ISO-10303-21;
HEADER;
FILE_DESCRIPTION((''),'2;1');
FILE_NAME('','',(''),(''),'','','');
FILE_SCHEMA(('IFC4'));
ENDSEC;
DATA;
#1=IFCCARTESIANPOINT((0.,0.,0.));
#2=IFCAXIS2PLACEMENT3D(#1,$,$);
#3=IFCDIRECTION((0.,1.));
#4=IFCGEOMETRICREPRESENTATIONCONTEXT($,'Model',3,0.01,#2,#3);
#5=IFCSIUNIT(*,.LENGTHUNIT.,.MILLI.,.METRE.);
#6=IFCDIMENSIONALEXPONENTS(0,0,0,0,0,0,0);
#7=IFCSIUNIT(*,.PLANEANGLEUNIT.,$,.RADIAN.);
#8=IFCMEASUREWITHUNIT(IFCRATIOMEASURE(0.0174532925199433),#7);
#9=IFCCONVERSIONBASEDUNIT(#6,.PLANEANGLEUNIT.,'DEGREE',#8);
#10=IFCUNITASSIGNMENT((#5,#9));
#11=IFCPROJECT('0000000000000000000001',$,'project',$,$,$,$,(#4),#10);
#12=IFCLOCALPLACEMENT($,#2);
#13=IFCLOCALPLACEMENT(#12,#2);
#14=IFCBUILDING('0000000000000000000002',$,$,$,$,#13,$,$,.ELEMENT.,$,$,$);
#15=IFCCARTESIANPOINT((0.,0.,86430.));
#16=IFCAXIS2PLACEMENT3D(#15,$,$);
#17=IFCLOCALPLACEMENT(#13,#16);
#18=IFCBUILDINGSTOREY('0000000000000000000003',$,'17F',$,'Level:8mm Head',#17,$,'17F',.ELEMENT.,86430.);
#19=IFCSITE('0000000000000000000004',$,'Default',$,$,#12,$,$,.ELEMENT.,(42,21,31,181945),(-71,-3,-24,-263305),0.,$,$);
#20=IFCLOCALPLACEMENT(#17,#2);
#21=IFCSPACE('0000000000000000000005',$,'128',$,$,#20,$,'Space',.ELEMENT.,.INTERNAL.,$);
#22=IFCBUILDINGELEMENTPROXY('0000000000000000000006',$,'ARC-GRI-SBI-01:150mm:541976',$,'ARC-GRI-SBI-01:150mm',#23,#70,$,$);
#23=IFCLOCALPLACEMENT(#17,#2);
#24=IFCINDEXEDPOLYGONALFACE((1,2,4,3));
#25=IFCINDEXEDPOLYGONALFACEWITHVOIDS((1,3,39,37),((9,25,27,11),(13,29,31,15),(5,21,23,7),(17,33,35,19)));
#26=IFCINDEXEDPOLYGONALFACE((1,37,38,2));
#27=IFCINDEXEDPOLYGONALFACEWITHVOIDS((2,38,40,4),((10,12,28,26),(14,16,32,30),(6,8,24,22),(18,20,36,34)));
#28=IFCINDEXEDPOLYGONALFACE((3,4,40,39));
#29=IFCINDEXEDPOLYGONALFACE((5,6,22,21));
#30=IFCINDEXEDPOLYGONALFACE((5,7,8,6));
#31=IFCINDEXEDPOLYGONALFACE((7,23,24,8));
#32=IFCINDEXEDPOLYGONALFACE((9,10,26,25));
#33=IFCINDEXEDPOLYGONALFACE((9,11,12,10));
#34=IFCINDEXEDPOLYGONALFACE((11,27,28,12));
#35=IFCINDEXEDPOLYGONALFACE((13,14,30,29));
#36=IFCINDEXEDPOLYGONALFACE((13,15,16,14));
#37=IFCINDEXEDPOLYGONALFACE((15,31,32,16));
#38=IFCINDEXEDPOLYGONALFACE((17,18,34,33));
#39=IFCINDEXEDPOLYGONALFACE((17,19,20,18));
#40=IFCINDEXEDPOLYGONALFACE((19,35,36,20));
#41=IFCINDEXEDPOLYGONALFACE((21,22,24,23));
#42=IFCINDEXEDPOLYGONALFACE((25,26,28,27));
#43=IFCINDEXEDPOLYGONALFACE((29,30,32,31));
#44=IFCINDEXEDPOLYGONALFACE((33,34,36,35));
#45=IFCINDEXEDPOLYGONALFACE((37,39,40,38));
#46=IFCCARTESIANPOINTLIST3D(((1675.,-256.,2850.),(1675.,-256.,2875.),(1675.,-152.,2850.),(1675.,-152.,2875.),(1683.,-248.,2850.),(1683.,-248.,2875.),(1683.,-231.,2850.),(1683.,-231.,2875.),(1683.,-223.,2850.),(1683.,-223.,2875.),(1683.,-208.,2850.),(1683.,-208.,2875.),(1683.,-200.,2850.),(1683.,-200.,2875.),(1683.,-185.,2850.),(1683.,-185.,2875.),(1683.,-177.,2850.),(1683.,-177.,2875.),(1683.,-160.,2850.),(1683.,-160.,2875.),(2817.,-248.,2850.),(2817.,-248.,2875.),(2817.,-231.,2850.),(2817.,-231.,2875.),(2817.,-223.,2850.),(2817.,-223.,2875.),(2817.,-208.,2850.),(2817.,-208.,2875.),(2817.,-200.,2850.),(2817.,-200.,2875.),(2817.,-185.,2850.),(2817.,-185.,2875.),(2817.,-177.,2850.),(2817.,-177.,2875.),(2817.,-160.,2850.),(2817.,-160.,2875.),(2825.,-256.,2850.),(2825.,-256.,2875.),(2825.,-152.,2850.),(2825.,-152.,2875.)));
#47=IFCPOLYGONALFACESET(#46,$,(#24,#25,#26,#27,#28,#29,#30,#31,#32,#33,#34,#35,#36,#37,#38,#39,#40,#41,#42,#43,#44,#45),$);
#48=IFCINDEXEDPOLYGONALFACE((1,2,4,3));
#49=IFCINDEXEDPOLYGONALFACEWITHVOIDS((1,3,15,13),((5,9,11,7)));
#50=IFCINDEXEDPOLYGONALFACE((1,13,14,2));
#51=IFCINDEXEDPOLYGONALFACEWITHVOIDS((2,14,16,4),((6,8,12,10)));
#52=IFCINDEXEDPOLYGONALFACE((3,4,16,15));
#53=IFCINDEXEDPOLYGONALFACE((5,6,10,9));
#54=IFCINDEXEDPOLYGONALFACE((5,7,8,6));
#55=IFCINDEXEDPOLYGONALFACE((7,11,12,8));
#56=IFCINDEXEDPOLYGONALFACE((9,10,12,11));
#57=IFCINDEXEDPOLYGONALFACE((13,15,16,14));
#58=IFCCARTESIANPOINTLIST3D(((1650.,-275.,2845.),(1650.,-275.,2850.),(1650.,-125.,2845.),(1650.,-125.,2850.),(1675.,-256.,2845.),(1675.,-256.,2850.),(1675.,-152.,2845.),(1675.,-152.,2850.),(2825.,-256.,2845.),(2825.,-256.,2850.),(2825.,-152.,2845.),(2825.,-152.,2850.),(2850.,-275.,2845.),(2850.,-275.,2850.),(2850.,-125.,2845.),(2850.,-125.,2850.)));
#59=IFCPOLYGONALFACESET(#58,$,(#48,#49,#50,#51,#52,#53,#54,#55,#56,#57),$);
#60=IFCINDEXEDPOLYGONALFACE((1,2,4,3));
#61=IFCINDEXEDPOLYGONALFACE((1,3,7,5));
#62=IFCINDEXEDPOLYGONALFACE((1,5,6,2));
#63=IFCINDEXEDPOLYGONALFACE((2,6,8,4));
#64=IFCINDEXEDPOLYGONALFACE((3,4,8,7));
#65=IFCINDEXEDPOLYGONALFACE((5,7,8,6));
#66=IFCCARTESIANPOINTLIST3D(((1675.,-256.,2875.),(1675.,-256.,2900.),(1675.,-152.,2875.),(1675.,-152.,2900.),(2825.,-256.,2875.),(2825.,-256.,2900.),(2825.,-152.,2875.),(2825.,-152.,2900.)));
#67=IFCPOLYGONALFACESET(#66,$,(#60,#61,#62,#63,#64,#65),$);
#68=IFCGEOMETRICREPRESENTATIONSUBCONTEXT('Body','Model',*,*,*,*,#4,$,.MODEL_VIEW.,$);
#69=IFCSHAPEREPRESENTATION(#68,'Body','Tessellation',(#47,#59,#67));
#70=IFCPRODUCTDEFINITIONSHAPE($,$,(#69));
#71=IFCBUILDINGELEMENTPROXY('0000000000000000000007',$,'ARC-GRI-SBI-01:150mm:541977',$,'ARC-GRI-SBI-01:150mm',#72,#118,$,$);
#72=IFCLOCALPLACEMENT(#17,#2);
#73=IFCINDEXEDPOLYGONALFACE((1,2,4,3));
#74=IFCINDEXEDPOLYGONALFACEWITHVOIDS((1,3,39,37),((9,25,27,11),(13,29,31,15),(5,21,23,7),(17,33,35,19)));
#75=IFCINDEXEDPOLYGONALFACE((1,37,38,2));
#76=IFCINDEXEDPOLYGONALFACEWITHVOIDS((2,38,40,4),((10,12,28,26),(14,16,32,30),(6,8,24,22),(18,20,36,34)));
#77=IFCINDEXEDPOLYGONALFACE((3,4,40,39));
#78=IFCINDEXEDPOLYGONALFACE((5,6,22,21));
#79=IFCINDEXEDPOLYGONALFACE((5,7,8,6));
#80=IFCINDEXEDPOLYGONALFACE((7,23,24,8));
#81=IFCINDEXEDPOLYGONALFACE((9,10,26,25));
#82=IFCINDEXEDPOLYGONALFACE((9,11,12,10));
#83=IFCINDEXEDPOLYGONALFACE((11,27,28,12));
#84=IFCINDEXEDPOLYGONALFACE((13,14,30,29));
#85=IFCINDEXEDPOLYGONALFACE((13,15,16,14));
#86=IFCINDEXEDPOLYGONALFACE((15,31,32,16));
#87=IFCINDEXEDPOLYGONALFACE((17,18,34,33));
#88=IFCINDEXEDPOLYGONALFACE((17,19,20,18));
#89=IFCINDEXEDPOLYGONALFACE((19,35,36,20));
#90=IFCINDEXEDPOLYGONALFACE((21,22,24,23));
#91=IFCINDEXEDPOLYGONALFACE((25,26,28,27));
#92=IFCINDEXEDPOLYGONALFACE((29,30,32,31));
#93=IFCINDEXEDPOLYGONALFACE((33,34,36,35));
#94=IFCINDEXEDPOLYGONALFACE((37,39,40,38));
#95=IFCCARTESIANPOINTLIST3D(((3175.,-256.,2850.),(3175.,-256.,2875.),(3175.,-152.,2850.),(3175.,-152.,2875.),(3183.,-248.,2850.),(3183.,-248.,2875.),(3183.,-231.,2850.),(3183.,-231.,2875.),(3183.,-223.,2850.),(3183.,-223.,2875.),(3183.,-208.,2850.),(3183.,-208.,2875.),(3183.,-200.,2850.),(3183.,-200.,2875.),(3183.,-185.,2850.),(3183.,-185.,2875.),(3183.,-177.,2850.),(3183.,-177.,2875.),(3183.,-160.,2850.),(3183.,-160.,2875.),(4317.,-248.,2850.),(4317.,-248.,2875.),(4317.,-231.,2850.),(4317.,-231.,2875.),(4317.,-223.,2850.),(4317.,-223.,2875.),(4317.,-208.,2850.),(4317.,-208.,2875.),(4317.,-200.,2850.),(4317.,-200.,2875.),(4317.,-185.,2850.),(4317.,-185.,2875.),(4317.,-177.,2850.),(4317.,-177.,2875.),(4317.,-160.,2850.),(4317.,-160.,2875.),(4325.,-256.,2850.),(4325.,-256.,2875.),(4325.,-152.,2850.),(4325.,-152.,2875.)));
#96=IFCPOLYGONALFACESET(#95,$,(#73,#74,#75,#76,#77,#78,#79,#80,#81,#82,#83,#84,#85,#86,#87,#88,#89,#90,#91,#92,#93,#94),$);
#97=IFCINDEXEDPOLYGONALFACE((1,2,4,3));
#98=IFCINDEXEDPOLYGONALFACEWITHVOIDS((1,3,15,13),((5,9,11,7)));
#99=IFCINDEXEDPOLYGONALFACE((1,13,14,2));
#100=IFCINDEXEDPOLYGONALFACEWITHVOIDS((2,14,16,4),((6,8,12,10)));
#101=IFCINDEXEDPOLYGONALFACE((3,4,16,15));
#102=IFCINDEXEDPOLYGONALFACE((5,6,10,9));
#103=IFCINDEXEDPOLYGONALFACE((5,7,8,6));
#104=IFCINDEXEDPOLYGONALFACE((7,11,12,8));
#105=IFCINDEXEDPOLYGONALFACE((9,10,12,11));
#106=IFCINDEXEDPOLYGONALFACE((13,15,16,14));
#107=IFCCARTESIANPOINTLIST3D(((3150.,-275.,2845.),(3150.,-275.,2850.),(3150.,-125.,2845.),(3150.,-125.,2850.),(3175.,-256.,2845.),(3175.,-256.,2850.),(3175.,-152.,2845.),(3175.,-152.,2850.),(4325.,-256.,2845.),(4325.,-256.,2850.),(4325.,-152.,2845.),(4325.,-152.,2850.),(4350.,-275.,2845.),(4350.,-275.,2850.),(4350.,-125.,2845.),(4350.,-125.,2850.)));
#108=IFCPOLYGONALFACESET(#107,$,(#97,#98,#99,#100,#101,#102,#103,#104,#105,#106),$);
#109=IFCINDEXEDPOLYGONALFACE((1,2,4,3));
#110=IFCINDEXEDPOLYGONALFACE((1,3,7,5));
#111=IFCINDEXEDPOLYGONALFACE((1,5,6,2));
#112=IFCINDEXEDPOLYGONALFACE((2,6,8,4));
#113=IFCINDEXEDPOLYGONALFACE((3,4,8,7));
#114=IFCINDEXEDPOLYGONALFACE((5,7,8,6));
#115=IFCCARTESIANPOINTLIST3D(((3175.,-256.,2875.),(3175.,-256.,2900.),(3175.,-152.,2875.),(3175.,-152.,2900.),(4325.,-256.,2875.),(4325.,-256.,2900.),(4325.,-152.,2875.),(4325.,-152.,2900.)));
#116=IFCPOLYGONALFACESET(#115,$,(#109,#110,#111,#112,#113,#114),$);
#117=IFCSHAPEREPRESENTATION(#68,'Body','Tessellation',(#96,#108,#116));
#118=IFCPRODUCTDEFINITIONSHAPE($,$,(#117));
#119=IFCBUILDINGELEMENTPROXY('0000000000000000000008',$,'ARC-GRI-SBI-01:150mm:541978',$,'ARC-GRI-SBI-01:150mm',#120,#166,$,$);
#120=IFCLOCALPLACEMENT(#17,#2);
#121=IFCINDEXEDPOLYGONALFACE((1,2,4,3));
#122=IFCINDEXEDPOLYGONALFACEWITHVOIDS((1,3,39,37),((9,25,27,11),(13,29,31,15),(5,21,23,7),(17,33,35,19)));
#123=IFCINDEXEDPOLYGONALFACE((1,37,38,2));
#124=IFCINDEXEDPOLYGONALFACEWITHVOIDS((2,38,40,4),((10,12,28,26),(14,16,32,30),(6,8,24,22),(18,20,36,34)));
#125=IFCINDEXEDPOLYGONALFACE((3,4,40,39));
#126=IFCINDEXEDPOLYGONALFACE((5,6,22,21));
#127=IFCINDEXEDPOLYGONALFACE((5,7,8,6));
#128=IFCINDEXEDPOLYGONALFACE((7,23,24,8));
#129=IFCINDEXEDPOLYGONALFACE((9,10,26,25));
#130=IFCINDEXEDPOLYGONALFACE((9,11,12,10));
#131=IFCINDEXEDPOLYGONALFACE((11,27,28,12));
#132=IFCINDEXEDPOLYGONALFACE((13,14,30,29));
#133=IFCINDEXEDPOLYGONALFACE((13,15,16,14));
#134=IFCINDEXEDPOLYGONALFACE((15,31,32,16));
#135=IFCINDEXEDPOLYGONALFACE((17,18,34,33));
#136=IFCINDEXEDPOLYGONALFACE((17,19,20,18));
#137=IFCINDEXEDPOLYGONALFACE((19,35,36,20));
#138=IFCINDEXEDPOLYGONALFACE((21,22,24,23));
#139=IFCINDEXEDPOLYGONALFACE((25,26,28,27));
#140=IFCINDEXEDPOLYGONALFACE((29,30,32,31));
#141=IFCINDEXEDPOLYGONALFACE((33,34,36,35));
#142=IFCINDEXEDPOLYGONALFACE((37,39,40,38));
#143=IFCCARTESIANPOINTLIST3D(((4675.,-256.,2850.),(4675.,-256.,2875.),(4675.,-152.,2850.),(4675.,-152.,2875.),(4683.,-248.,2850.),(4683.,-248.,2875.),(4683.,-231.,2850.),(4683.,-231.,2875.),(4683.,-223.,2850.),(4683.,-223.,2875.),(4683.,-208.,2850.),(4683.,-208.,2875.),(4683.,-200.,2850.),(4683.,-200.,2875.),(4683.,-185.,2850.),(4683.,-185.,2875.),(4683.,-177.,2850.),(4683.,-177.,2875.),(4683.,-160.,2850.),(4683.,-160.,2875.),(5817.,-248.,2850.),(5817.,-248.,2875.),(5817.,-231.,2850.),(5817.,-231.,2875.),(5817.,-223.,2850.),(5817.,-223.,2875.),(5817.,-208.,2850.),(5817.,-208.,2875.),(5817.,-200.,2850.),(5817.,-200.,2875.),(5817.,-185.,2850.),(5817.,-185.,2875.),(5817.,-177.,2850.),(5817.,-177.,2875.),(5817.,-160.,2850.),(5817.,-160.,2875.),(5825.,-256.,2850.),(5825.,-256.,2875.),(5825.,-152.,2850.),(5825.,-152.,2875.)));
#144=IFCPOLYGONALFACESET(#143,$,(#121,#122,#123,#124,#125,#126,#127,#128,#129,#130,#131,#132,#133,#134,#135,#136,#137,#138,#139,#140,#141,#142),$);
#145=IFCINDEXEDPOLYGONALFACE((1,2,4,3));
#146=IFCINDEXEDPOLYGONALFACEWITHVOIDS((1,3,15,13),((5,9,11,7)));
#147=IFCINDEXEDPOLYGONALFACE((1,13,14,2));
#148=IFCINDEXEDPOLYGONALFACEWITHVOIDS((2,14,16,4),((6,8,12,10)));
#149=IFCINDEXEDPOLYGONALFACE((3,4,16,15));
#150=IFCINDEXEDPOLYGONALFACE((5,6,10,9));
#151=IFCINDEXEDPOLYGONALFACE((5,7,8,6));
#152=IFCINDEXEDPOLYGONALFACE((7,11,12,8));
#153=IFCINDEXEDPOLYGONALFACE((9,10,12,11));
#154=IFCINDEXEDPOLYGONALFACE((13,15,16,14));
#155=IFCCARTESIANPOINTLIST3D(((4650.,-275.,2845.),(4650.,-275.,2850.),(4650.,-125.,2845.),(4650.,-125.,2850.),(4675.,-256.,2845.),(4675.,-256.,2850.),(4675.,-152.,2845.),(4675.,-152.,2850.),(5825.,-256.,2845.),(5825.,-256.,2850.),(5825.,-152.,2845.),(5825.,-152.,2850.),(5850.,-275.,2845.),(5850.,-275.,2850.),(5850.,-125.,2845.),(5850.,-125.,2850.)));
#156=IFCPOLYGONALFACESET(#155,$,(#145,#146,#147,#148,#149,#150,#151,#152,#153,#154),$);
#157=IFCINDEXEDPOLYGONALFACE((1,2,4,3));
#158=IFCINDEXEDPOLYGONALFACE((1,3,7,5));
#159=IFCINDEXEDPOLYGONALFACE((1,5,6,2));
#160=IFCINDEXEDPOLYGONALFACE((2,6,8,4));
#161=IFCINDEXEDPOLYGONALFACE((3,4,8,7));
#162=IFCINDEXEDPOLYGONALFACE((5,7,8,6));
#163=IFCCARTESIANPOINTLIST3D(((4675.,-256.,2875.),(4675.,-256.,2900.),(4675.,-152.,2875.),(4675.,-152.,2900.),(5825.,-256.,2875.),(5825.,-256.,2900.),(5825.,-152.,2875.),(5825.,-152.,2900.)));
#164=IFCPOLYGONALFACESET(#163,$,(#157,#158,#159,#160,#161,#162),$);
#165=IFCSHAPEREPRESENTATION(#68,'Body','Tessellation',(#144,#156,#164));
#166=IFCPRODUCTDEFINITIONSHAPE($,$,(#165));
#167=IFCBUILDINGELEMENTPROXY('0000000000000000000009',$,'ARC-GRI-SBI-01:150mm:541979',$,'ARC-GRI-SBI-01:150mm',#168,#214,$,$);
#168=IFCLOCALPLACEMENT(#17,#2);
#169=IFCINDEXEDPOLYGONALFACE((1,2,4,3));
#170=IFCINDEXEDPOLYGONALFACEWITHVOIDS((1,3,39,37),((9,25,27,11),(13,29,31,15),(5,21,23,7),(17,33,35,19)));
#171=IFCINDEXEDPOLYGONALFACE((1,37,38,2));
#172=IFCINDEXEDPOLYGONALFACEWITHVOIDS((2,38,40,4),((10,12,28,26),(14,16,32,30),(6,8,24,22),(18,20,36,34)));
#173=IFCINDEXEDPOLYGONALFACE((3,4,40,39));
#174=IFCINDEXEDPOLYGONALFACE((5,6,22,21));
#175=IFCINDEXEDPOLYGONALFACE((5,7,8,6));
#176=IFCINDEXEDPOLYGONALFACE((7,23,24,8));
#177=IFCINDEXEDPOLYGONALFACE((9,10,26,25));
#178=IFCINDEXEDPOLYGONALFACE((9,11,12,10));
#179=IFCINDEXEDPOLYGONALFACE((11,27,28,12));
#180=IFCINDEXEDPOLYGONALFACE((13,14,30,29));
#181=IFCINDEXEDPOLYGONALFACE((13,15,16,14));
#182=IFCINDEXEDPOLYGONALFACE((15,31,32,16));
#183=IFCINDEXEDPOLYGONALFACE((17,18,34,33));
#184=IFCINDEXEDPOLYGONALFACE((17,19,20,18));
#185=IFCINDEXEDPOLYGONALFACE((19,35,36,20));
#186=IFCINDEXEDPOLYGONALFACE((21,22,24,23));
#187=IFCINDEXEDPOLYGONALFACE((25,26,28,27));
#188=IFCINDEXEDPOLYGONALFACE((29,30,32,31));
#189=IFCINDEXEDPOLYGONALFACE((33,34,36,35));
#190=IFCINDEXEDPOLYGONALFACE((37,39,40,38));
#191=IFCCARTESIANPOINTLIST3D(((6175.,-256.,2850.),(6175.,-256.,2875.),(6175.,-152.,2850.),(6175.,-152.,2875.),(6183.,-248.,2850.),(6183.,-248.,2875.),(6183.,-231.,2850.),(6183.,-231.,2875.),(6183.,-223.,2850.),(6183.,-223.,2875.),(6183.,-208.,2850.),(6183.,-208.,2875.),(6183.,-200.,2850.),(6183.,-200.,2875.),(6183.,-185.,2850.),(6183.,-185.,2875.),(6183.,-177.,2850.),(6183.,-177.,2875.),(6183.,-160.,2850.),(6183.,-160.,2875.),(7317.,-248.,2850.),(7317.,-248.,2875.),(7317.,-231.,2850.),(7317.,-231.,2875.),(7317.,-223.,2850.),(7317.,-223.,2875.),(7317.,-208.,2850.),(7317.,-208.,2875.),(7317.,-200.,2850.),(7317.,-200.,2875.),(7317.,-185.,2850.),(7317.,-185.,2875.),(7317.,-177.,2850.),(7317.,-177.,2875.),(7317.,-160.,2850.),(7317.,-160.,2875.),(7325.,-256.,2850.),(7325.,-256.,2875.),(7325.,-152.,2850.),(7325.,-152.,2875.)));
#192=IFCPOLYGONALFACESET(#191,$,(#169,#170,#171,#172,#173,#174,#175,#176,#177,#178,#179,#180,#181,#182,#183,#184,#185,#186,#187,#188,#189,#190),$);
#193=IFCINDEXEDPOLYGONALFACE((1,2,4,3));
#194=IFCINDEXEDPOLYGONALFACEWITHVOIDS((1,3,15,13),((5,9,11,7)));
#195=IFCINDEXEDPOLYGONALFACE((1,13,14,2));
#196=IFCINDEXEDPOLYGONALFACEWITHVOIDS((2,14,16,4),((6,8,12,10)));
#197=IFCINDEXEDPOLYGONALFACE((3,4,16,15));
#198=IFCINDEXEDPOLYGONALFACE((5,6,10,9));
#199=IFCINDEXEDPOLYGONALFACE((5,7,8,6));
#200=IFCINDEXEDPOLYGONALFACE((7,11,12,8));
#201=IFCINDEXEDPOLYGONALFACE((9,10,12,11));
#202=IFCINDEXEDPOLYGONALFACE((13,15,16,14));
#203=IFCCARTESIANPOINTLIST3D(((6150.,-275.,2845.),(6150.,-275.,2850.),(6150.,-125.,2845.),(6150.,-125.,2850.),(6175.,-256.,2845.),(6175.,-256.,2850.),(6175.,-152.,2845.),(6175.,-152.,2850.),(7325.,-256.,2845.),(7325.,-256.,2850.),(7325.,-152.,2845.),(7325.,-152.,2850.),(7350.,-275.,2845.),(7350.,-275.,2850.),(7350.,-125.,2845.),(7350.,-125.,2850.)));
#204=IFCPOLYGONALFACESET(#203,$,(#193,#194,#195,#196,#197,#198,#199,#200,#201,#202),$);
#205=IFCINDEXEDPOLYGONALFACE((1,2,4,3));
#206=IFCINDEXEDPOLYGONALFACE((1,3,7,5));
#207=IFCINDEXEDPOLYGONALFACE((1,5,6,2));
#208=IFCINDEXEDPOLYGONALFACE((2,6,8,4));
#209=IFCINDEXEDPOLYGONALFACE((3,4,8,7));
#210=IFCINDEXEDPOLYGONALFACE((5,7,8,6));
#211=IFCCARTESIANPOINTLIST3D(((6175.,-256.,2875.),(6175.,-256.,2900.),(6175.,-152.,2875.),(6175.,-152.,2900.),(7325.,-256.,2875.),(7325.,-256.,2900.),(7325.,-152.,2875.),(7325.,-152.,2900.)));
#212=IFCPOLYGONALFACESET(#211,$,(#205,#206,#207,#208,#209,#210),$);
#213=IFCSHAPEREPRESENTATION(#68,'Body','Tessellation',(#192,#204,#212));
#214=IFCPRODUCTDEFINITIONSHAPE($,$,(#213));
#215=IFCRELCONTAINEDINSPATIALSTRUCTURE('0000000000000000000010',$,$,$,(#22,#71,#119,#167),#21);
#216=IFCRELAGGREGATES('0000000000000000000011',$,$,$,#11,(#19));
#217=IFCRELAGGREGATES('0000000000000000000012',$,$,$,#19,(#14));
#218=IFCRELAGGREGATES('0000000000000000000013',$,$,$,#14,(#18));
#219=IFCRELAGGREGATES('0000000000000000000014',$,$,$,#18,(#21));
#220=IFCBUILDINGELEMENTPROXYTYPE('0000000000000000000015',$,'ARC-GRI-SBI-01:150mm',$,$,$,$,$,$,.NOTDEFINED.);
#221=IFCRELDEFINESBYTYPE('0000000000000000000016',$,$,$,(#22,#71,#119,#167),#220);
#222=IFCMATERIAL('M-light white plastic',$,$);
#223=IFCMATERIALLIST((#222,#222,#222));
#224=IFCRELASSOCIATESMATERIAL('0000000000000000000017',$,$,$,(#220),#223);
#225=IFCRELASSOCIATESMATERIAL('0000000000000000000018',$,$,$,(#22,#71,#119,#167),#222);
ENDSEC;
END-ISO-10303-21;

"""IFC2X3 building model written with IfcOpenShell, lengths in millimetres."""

from ifc_helpers import new_model, entity, si_unit, converted_unit, direction, frame, origin, origin_2d_with_axis, place, context, subcontext, project, spatial, polyline, rectangle, outline, extrude, source, transform, mapped, material, material_list, type_object, type_shapes, element, save


model = new_model("IFC2X3")

# Units and contexts
model_context = context("Model", 3, precision=0.01, world=origin(), true_north=direction((0.0, 1.0)))
body_context = subcontext(model_context, "Body", "Model", "MODEL_VIEW")
ifc_project = project(units=[si_unit("LENGTHUNIT", "METRE", prefix="MILLI"), converted_unit("PLANEANGLEUNIT", "DEGREE", entity("IfcRatioMeasure", 0.0174532925199433), si_unit("PLANEANGLEUNIT", "RADIAN"), dimensions=[0, 0, 0, 0, 0, 0, 0])], contexts=[model_context])

# Site, building, storey
site_placement = place(None, origin())
site = spatial("IfcSite", under=ifc_project, at=site_placement, Name="Default", CompositionType="ELEMENT", RefLatitude=(42, 21, 31, 181945), RefLongitude=(-71, -3, -24, -263305), RefElevation=0.0)
building_placement = place(site_placement, origin())
building = spatial("IfcBuilding", under=site, at=building_placement, CompositionType="ELEMENT")
storey_placement = place(building_placement, frame((0.0, 0.0, 86430.0)))
storey = spatial("IfcBuildingStorey", under=building, at=storey_placement, Name="17F", ObjectType="Level:8mm Head", LongName="17F", CompositionType="ELEMENT", Elevation=86430.0)

# Shared definitions
space_placement = place(storey_placement, origin())
space = spatial("IfcSpace", under=storey, at=space_placement, Name="128", LongName="Space", CompositionType="ELEMENT", InteriorOrExteriorSpace="INTERNAL")

# Building element proxies
ifc_material_1 = material(Name="M-light white plastic")
ifc_material_list = material_list([ifc_material_1, ifc_material_1, ifc_material_1])
building_element_proxy_type = type_object("IfcBuildingElementProxyType", Name="ARC-GRI-SBI-01:150mm", PredefinedType="NOTDEFINED", material=ifc_material_list)
shared_shape = source(origin(), body_context, "Body", "SweptSolid", [
    extrude(outline(polyline([(-575.0, -52.0), (575.0, -52.0), (575.0, 52.0), (-575.0, 52.0), (-575.0, -52.0)]), holes=[polyline([(-567.0, -44.0), (-567.0, -27.0), (567.0, -27.0), (567.0, -44.0), (-567.0, -44.0)]), polyline([(567.0, -4.0), (567.0, -19.0), (-567.0, -19.0), (-567.0, -4.0), (567.0, -4.0)]), polyline([(-567.0, 44.0), (567.0, 44.0), (567.0, 27.0), (-567.0, 27.0), (-567.0, 44.0)]), polyline([(567.0, 4.0), (-567.0, 4.0), (-567.0, 19.0), (567.0, 19.0), (567.0, 4.0)])]), frame((425.0, 4.0, 4000.0), z_axis=(0.0, 0.0, 1.0), x_axis=(-1.0, 0.0, 0.0)), (0.0, 0.0, 1.0), 25.0),
    extrude(outline(polyline([(-600.0, -75.0), (600.0, -75.0), (600.0, 75.0), (-600.0, 75.0), (-600.0, -75.0)]), holes=[polyline([(-575.0, -56.0), (-575.0, 48.0), (575.0, 48.0), (575.0, -56.0), (-575.0, -56.0)])]), frame((425.0, 0.0, 3995.0), z_axis=(0.0, 0.0, 1.0), x_axis=(-1.0, 0.0, 0.0)), (0.0, 0.0, 1.0), 5.0),
    extrude(rectangle(XDim=1150.0, YDim=104.0, at=origin_2d_with_axis()), frame((425.0, 4.0, 4025.0), z_axis=(0.0, 0.0, 1.0), x_axis=(-1.0, 0.0, 0.0)), (0.0, 0.0, 1.0), 25.0),
])
type_shapes(building_element_proxy_type, [shared_shape])
for number, where, z_axis, x_axis, name in (
    (1, (2675.0, -200.0, -1150.0), (0.0, 0.0, 1.0), (-1.0, 0.0, 0.0), "ARC-GRI-SBI-01:150mm:541976"),
    (2, (4175.0, -200.0, -1150.0), (0.0, 0.0, 1.0), (-1.0, 0.0, 0.0), "ARC-GRI-SBI-01:150mm:541977"),
    (3, (5675.0, -200.0, -1150.0), (0.0, 0.0, 1.0), (-1.0, 0.0, 0.0), "ARC-GRI-SBI-01:150mm:541978"),
    (4, (7175.0, -200.0, -1150.0), (0.0, 0.0, 1.0), (-1.0, 0.0, 0.0), "ARC-GRI-SBI-01:150mm:541979"),
):
    element("IfcBuildingElementProxy", number, at=place(space_placement, frame(where, z_axis=z_axis, x_axis=x_axis)), inside=space, type_object=building_element_proxy_type, material=ifc_material_1, Name=name, ObjectType="ARC-GRI-SBI-01:150mm", context=body_context, shape_type="MappedRepresentation", body=[
        mapped(shared_shape, transform((0.0, 0.0, 0.0), scale=1.0)),
    ])

save(model, "model.ifc")
